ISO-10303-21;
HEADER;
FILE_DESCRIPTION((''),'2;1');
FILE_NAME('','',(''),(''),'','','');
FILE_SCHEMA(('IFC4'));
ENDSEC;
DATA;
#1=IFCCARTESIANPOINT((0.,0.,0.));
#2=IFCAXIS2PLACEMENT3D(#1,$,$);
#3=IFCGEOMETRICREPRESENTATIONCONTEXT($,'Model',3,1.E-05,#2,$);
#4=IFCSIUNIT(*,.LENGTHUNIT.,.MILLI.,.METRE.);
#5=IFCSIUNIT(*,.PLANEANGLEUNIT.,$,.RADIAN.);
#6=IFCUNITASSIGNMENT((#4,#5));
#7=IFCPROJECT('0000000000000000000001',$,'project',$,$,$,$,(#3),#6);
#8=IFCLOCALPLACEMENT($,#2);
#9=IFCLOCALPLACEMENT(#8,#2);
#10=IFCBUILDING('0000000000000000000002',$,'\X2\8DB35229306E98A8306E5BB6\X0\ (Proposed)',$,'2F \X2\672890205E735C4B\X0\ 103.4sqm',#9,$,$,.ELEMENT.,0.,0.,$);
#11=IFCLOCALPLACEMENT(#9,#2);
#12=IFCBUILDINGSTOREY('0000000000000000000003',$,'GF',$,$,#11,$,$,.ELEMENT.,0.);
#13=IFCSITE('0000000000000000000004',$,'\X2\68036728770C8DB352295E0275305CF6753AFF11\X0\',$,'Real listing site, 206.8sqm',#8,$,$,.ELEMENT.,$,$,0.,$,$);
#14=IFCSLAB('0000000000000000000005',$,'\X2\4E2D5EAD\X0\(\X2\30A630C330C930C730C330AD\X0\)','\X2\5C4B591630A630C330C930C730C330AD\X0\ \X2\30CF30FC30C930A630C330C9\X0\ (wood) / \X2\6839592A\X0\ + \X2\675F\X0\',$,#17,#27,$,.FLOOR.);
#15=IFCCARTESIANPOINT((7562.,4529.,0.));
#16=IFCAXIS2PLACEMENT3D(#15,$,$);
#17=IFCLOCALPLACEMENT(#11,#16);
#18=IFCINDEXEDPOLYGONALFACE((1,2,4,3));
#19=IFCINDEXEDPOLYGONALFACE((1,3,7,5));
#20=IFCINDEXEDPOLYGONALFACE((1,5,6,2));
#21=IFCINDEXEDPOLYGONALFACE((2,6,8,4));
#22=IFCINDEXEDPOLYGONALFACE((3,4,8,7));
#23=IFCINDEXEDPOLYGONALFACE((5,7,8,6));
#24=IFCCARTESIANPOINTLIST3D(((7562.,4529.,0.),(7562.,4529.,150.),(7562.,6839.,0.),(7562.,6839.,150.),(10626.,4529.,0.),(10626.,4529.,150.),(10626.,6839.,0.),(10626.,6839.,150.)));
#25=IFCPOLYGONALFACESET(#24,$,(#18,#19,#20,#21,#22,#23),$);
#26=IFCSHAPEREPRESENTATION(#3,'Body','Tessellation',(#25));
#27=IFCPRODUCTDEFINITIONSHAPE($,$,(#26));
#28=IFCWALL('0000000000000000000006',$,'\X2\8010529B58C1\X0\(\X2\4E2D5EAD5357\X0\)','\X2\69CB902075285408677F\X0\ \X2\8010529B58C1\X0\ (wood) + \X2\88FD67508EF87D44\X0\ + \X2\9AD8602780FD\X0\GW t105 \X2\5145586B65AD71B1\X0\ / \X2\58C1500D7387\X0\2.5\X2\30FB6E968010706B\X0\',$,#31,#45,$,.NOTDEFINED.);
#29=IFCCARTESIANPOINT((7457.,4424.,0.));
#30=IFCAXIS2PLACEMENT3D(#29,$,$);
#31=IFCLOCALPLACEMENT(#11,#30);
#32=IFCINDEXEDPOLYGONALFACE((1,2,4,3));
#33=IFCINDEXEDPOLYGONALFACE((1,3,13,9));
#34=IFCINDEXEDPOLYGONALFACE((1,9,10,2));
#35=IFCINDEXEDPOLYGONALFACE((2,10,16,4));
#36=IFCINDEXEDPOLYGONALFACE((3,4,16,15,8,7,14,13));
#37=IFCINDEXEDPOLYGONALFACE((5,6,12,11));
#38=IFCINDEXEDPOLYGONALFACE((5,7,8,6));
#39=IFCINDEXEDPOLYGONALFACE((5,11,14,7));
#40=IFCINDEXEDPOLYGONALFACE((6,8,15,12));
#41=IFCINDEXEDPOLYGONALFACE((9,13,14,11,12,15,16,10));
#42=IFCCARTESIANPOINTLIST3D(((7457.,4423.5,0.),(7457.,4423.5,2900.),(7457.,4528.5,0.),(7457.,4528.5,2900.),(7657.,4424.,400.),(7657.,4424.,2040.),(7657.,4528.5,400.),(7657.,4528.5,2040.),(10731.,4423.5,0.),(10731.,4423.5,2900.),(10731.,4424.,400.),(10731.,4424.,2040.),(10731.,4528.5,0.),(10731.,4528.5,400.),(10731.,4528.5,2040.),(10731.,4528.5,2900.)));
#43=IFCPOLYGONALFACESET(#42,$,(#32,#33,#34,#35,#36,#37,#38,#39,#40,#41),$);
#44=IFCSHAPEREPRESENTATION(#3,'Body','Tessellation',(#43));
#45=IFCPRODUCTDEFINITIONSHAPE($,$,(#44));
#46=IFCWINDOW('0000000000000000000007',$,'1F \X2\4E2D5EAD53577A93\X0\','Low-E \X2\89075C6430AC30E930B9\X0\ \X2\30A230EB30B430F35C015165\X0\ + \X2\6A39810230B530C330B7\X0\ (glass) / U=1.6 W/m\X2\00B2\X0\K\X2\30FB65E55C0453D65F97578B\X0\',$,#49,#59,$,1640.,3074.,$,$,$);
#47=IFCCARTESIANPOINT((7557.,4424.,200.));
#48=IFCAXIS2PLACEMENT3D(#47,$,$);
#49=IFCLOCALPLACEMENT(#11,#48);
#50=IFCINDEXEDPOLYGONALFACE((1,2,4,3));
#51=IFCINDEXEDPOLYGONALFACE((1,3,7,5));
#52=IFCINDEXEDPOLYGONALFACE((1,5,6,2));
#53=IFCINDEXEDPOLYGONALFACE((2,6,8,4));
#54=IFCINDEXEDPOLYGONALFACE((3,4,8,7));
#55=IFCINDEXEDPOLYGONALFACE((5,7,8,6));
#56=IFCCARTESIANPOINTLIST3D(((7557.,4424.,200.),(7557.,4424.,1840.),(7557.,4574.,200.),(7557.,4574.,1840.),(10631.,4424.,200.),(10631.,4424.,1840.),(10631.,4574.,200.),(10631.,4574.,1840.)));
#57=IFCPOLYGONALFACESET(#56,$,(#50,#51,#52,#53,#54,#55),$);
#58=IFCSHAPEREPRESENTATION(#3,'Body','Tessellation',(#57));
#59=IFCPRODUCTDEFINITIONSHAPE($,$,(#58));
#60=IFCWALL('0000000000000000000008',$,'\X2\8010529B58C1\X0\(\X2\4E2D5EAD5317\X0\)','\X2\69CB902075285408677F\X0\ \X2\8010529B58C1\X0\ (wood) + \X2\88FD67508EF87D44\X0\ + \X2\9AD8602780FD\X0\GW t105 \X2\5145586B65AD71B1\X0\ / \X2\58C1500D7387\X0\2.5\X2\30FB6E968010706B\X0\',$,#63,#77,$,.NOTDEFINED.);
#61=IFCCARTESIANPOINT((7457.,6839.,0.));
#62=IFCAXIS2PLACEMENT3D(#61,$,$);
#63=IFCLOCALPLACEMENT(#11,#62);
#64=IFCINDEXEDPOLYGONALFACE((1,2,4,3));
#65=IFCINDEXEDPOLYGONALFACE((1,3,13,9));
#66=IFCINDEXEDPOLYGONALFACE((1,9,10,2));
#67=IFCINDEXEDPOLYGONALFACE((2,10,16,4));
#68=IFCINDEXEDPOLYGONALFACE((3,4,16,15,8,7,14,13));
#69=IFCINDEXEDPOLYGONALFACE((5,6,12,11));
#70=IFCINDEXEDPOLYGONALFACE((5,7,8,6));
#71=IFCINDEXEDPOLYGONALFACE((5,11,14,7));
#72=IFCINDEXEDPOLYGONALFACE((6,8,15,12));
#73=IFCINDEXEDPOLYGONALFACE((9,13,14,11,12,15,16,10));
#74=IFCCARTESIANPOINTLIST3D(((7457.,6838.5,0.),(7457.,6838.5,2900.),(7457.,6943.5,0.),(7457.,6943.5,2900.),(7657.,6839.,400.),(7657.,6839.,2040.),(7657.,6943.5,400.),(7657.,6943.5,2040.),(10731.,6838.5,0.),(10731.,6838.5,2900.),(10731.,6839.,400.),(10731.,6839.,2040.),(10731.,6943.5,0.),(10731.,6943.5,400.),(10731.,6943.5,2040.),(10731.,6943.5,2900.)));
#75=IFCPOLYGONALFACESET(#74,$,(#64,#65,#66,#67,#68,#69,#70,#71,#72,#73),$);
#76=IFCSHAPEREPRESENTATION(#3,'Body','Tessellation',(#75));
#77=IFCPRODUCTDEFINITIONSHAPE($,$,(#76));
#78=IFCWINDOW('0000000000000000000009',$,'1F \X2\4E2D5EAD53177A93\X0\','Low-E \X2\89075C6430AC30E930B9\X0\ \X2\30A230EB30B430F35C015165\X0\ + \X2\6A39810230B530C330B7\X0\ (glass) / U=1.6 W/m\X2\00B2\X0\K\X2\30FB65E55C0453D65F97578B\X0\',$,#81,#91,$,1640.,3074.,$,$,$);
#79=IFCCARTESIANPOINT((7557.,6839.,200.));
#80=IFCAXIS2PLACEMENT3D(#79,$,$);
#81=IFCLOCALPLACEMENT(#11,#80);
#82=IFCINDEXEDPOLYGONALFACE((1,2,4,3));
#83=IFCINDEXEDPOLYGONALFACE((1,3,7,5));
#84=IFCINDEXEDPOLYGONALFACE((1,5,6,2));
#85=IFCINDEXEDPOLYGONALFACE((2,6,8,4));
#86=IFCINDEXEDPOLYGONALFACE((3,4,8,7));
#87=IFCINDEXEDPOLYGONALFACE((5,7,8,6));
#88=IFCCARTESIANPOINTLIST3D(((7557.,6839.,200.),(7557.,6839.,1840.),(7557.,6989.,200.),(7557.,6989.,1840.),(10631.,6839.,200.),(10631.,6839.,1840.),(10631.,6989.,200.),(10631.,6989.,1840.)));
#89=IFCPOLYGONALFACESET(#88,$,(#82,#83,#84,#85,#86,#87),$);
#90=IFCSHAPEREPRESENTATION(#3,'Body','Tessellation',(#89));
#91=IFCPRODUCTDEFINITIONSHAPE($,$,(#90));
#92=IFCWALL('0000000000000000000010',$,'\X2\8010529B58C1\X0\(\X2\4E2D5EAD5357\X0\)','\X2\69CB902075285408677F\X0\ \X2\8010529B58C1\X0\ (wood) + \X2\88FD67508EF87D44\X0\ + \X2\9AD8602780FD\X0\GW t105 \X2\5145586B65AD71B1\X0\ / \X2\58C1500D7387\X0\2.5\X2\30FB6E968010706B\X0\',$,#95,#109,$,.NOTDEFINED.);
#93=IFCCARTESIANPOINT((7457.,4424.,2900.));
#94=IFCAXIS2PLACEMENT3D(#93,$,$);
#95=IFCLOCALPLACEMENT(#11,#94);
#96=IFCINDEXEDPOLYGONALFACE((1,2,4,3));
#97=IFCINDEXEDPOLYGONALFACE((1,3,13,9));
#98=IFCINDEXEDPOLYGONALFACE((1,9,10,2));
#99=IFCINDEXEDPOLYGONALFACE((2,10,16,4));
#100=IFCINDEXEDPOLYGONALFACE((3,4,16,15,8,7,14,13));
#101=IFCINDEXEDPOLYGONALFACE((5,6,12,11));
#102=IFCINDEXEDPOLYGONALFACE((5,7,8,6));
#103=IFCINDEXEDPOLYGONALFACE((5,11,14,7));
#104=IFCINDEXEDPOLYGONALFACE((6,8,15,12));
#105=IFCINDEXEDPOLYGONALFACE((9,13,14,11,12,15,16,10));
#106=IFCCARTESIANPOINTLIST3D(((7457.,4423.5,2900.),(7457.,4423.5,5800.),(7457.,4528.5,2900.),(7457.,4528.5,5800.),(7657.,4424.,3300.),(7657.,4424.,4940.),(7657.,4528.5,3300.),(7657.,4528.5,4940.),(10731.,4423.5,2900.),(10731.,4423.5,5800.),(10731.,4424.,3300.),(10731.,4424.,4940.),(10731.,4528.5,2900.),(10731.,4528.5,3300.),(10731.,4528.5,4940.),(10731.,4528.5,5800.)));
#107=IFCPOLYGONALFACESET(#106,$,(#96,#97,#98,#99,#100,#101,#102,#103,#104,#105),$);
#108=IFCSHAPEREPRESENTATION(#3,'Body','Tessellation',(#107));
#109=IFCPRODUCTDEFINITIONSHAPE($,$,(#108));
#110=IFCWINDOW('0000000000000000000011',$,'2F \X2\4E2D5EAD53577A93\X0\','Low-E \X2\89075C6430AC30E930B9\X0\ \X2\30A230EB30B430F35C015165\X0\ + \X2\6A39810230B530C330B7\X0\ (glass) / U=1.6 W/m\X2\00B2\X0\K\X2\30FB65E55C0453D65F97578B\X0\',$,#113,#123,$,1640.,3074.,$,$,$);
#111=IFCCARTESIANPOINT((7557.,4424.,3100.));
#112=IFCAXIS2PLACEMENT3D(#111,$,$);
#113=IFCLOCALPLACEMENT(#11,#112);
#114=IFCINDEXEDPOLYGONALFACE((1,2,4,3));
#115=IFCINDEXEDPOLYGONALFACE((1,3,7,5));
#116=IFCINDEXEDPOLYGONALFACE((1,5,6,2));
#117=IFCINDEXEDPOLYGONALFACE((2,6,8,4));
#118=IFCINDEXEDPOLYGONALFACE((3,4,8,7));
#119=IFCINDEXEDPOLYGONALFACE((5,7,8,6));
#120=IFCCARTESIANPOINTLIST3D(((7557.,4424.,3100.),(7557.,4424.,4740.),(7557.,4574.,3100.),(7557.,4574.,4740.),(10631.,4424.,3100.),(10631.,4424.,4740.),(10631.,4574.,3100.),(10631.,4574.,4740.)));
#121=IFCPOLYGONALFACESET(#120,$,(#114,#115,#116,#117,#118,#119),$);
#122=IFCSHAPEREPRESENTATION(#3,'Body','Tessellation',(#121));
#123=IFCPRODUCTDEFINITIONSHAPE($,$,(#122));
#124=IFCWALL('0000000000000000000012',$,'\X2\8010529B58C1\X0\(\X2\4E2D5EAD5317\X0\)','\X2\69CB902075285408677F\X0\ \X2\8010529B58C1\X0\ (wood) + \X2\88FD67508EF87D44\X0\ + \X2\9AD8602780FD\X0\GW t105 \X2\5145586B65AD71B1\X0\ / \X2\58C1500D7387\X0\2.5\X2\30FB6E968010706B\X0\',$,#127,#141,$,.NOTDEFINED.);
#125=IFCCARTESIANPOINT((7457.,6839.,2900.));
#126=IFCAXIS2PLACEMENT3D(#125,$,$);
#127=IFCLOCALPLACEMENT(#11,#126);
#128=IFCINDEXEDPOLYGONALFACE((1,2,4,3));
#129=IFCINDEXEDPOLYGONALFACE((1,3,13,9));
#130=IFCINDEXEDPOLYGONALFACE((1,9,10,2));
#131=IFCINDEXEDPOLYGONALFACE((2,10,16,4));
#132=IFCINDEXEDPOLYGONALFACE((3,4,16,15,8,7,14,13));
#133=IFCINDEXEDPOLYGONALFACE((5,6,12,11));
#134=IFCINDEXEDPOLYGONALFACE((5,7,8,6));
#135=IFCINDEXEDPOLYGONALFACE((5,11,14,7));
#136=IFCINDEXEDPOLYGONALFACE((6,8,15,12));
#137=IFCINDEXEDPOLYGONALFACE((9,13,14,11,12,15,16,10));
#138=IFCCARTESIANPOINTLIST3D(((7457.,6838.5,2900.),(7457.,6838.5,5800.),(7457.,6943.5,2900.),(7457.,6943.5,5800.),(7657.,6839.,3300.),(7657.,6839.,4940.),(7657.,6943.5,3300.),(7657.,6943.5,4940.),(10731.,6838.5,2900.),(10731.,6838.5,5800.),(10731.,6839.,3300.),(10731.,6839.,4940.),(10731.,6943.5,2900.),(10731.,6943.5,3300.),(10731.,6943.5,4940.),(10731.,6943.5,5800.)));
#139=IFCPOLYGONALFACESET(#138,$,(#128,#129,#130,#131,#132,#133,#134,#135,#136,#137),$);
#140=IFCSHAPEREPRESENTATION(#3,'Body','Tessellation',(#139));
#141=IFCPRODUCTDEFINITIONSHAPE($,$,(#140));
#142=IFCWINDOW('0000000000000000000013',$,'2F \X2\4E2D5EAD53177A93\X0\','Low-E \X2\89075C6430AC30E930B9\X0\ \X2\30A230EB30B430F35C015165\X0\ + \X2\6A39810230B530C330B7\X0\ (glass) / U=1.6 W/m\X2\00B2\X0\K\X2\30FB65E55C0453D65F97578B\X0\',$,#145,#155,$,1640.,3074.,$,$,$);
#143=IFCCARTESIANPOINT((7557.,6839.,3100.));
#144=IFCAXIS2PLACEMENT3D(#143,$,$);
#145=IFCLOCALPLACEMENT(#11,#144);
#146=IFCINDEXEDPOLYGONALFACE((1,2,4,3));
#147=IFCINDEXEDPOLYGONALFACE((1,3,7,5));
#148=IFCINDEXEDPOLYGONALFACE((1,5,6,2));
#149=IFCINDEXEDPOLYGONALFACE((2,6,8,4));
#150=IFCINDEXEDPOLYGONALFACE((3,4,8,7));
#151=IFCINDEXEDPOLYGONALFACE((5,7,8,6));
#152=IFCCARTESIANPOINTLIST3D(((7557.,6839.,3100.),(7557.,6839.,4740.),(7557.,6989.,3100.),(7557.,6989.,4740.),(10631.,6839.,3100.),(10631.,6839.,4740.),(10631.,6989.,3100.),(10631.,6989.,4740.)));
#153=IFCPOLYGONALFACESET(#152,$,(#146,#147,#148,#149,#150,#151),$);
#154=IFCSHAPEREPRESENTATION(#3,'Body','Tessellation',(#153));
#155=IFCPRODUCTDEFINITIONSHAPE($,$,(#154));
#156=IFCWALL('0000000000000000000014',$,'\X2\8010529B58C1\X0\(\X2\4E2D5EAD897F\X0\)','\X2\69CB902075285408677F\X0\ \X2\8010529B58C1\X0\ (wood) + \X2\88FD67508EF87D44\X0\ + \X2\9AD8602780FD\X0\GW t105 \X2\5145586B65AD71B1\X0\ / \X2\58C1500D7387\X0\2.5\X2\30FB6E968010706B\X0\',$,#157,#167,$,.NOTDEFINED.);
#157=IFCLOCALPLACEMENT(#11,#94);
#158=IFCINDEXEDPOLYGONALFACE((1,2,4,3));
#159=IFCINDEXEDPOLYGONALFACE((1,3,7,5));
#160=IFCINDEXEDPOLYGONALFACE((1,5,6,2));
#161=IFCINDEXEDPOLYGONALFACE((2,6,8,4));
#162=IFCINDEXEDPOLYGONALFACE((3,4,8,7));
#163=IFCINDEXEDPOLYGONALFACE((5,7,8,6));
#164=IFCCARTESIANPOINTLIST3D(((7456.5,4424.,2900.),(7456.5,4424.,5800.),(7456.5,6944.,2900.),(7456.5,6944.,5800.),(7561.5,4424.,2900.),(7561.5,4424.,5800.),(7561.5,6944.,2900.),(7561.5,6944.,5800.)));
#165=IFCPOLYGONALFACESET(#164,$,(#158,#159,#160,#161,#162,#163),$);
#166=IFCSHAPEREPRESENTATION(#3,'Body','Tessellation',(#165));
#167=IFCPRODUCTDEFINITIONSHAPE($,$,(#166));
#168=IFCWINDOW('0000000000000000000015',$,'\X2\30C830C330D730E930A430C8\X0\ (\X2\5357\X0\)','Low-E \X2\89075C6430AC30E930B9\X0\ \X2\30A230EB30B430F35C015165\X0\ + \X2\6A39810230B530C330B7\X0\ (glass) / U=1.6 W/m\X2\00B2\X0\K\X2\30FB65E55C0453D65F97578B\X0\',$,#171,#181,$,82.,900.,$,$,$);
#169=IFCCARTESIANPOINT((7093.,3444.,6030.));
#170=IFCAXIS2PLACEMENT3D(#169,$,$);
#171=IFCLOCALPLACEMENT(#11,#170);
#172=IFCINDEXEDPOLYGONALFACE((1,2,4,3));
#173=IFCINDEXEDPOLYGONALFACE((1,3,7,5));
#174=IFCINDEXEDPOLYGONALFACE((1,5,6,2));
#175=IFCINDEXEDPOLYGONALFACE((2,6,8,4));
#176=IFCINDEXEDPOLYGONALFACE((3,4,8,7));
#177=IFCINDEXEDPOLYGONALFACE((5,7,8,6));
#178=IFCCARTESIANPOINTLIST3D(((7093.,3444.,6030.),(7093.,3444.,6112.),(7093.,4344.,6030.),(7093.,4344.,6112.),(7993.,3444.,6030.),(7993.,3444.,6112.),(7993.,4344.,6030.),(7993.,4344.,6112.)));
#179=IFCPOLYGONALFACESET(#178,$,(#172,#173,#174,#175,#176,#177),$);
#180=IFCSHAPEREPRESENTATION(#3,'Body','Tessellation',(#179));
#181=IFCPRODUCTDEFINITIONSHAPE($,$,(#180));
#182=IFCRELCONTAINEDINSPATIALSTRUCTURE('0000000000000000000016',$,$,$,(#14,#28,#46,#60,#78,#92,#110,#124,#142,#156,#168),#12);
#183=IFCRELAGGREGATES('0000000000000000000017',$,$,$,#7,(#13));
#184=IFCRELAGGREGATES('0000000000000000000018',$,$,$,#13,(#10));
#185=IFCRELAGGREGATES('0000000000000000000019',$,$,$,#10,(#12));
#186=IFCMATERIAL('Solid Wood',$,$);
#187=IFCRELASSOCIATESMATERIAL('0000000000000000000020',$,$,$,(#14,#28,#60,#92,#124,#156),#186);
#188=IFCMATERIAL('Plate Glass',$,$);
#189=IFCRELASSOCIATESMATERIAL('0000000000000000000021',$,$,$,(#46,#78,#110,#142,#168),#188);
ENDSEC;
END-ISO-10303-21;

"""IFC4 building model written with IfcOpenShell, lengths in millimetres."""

from ifc_helpers import new_model, si_unit, frame, frame_2d, origin, place, context, project, spatial, rectangle, extrude, material, element, fill, save


model = new_model("IFC4")

# Units and contexts
model_context = context("Model", 3, precision=1e-05, world=origin())
ifc_project = project(units=[si_unit("LENGTHUNIT", "METRE", prefix="MILLI"), si_unit("PLANEANGLEUNIT", "RADIAN")], contexts=[model_context])

# Site, building, storey
site_placement = place(None, origin())
site = spatial("IfcSite", under=ifc_project, at=site_placement, Name="栃木県足利市田島町１", ObjectType="Real listing site, 206.8sqm", CompositionType="ELEMENT", RefElevation=0.0)
building_placement = place(site_placement, origin())
building = spatial("IfcBuilding", under=site, at=building_placement, Name="足利の風の家 (Proposed)", ObjectType="2F 木造平屋 103.4sqm", CompositionType="ELEMENT", ElevationOfRefHeight=0.0, ElevationOfTerrain=0.0)
storey_placement = place(building_placement, origin())
storey = spatial("IfcBuildingStorey", under=building, at=storey_placement, Name="GF", CompositionType="ELEMENT", Elevation=0.0)

# Slab
ifc_material_1 = material(Name="Solid Wood")
slab_placement = place(storey_placement, frame((7562.0, 4529.0, 0.0)))
element("IfcSlab", 1, at=slab_placement, inside=storey, material=ifc_material_1, Name="中庭(ウッドデッキ)", Description="屋外ウッドデッキ ハードウッド (wood) / 根太 + 束", PredefinedType="FLOOR", context=model_context, shape_type="SweptSolid", body=[
    extrude(rectangle(XDim=3064.0, YDim=2310.0, at=frame_2d((1532.0, 1155.0))), frame((7562.0, 4529.0, 0.0)), (0.0, 0.0, 1.0), 150.0),
])

# Walls, openings, windows
wall_1_placement = place(storey_placement, frame((7457.0, 4424.0, 0.0)))
wall_1 = element("IfcWall", 2, at=wall_1_placement, inside=storey, material=ifc_material_1, Name="耐力壁(中庭南)", Description="構造用合板 耐力壁 (wood) + 製材軸組 + 高性能GW t105 充填断熱 / 壁倍率2.5・準耐火", PredefinedType="NOTDEFINED", context=model_context, shape_type="SweptSolid", body=[
    extrude(rectangle(XDim=3274.0, YDim=105.0, at=frame_2d((1637.0, 52.0))), frame((7457.0, 4424.0, 0.0)), (0.0, 0.0, 1.0), 2900.0),
])
opening_1_placement = place(storey_placement, frame((7557.0, 4424.0, 200.0)))
opening_1 = element("IfcOpeningElement", 3, at=opening_1_placement, cuts=wall_1, PredefinedType="NOTDEFINED", context=model_context, shape_type="SweptSolid", body=[
    extrude(rectangle(XDim=3074.0, YDim=150.0, at=frame_2d((1537.0, 75.0))), frame((7557.0, 4424.0, 200.0)), (0.0, 0.0, 1.0), 1640.0),
])
ifc_material_2 = material(Name="Plate Glass")
window_1_placement = place(storey_placement, frame((7557.0, 4424.0, 200.0)))
window_1 = element("IfcWindow", 4, at=window_1_placement, inside=storey, material=ifc_material_2, Name="1F 中庭南窓", Description="Low-E 複層ガラス アルゴン封入 + 樹脂サッシ (glass) / U=1.6 W/m²K・日射取得型", OverallHeight=1640.0, OverallWidth=3074.0, context=model_context, shape_type="SweptSolid", body=[
    extrude(rectangle(XDim=3074.0, YDim=150.0, at=frame_2d((1537.0, 75.0))), frame((7557.0, 4424.0, 200.0)), (0.0, 0.0, 1.0), 1640.0),
])
fill(opening_1, window_1)
wall_2_placement = place(storey_placement, frame((7457.0, 6839.0, 0.0)))
wall_2 = element("IfcWall", 5, at=wall_2_placement, inside=storey, material=ifc_material_1, Name="耐力壁(中庭北)", Description="構造用合板 耐力壁 (wood) + 製材軸組 + 高性能GW t105 充填断熱 / 壁倍率2.5・準耐火", PredefinedType="NOTDEFINED", context=model_context, shape_type="SweptSolid", body=[
    extrude(rectangle(XDim=3274.0, YDim=105.0, at=frame_2d((1637.0, 52.0))), frame((7457.0, 6839.0, 0.0)), (0.0, 0.0, 1.0), 2900.0),
])
opening_2_placement = place(storey_placement, frame((7557.0, 6839.0, 200.0)))
opening_2 = element("IfcOpeningElement", 6, at=opening_2_placement, cuts=wall_2, PredefinedType="NOTDEFINED", context=model_context, shape_type="SweptSolid", body=[
    extrude(rectangle(XDim=3074.0, YDim=150.0, at=frame_2d((1537.0, 75.0))), frame((7557.0, 6839.0, 200.0)), (0.0, 0.0, 1.0), 1640.0),
])
window_2_placement = place(storey_placement, frame((7557.0, 6839.0, 200.0)))
window_2 = element("IfcWindow", 7, at=window_2_placement, inside=storey, material=ifc_material_2, Name="1F 中庭北窓", Description="Low-E 複層ガラス アルゴン封入 + 樹脂サッシ (glass) / U=1.6 W/m²K・日射取得型", OverallHeight=1640.0, OverallWidth=3074.0, context=model_context, shape_type="SweptSolid", body=[
    extrude(rectangle(XDim=3074.0, YDim=150.0, at=frame_2d((1537.0, 75.0))), frame((7557.0, 6839.0, 200.0)), (0.0, 0.0, 1.0), 1640.0),
])
fill(opening_2, window_2)

# Walls, openings, windows
wall_3_placement = place(storey_placement, frame((7457.0, 4424.0, 2900.0)))
wall_3 = element("IfcWall", 8, at=wall_3_placement, inside=storey, material=ifc_material_1, Name="耐力壁(中庭南)", Description="構造用合板 耐力壁 (wood) + 製材軸組 + 高性能GW t105 充填断熱 / 壁倍率2.5・準耐火", PredefinedType="NOTDEFINED", context=model_context, shape_type="SweptSolid", body=[
    extrude(rectangle(XDim=3274.0, YDim=105.0, at=frame_2d((1637.0, 52.0))), frame((7457.0, 4424.0, 2900.0)), (0.0, 0.0, 1.0), 2900.0),
])
opening_3_placement = place(storey_placement, frame((7557.0, 4424.0, 3100.0)))
opening_3 = element("IfcOpeningElement", 9, at=opening_3_placement, cuts=wall_3, PredefinedType="NOTDEFINED", context=model_context, shape_type="SweptSolid", body=[
    extrude(rectangle(XDim=3074.0, YDim=150.0, at=frame_2d((1537.0, 75.0))), frame((7557.0, 4424.0, 3100.0)), (0.0, 0.0, 1.0), 1640.0),
])
window_3_placement = place(storey_placement, frame((7557.0, 4424.0, 3100.0)))
window_3 = element("IfcWindow", 10, at=window_3_placement, inside=storey, material=ifc_material_2, Name="2F 中庭南窓", Description="Low-E 複層ガラス アルゴン封入 + 樹脂サッシ (glass) / U=1.6 W/m²K・日射取得型", OverallHeight=1640.0, OverallWidth=3074.0, context=model_context, shape_type="SweptSolid", body=[
    extrude(rectangle(XDim=3074.0, YDim=150.0, at=frame_2d((1537.0, 75.0))), frame((7557.0, 4424.0, 3100.0)), (0.0, 0.0, 1.0), 1640.0),
])
fill(opening_3, window_3)
wall_4_placement = place(storey_placement, frame((7457.0, 6839.0, 2900.0)))
wall_4 = element("IfcWall", 11, at=wall_4_placement, inside=storey, material=ifc_material_1, Name="耐力壁(中庭北)", Description="構造用合板 耐力壁 (wood) + 製材軸組 + 高性能GW t105 充填断熱 / 壁倍率2.5・準耐火", PredefinedType="NOTDEFINED", context=model_context, shape_type="SweptSolid", body=[
    extrude(rectangle(XDim=3274.0, YDim=105.0, at=frame_2d((1637.0, 52.0))), frame((7457.0, 6839.0, 2900.0)), (0.0, 0.0, 1.0), 2900.0),
])
opening_4_placement = place(storey_placement, frame((7557.0, 6839.0, 3100.0)))
opening_4 = element("IfcOpeningElement", 12, at=opening_4_placement, cuts=wall_4, PredefinedType="NOTDEFINED", context=model_context, shape_type="SweptSolid", body=[
    extrude(rectangle(XDim=3074.0, YDim=150.0, at=frame_2d((1537.0, 75.0))), frame((7557.0, 6839.0, 3100.0)), (0.0, 0.0, 1.0), 1640.0),
])
window_4_placement = place(storey_placement, frame((7557.0, 6839.0, 3100.0)))
window_4 = element("IfcWindow", 13, at=window_4_placement, inside=storey, material=ifc_material_2, Name="2F 中庭北窓", Description="Low-E 複層ガラス アルゴン封入 + 樹脂サッシ (glass) / U=1.6 W/m²K・日射取得型", OverallHeight=1640.0, OverallWidth=3074.0, context=model_context, shape_type="SweptSolid", body=[
    extrude(rectangle(XDim=3074.0, YDim=150.0, at=frame_2d((1537.0, 75.0))), frame((7557.0, 6839.0, 3100.0)), (0.0, 0.0, 1.0), 1640.0),
])
fill(opening_4, window_4)

# Wall
wall_5_placement = place(storey_placement, frame((7457.0, 4424.0, 2900.0)))
element("IfcWall", 14, at=wall_5_placement, inside=storey, material=ifc_material_1, Name="耐力壁(中庭西)", Description="構造用合板 耐力壁 (wood) + 製材軸組 + 高性能GW t105 充填断熱 / 壁倍率2.5・準耐火", PredefinedType="NOTDEFINED", context=model_context, shape_type="SweptSolid", body=[
    extrude(rectangle(XDim=105.0, YDim=2520.0, at=frame_2d((52.0, 1260.0))), frame((7457.0, 4424.0, 2900.0)), (0.0, 0.0, 1.0), 2900.0),
])

# Window
window_5_placement = place(storey_placement, frame((7093.0, 3444.0, 6030.0)))
element("IfcWindow", 15, at=window_5_placement, inside=storey, material=ifc_material_2, Name="トップライト (南)", Description="Low-E 複層ガラス アルゴン封入 + 樹脂サッシ (glass) / U=1.6 W/m²K・日射取得型", OverallHeight=82.0, OverallWidth=900.0, context=model_context, shape_type="SweptSolid", body=[
    extrude(rectangle(XDim=900.0, YDim=900.0, at=frame_2d((450.0, 450.0))), frame((7093.0, 3444.0, 6030.0)), (0.0, 0.0, 1.0), 82.0),
])

save(model, "model.ifc")
